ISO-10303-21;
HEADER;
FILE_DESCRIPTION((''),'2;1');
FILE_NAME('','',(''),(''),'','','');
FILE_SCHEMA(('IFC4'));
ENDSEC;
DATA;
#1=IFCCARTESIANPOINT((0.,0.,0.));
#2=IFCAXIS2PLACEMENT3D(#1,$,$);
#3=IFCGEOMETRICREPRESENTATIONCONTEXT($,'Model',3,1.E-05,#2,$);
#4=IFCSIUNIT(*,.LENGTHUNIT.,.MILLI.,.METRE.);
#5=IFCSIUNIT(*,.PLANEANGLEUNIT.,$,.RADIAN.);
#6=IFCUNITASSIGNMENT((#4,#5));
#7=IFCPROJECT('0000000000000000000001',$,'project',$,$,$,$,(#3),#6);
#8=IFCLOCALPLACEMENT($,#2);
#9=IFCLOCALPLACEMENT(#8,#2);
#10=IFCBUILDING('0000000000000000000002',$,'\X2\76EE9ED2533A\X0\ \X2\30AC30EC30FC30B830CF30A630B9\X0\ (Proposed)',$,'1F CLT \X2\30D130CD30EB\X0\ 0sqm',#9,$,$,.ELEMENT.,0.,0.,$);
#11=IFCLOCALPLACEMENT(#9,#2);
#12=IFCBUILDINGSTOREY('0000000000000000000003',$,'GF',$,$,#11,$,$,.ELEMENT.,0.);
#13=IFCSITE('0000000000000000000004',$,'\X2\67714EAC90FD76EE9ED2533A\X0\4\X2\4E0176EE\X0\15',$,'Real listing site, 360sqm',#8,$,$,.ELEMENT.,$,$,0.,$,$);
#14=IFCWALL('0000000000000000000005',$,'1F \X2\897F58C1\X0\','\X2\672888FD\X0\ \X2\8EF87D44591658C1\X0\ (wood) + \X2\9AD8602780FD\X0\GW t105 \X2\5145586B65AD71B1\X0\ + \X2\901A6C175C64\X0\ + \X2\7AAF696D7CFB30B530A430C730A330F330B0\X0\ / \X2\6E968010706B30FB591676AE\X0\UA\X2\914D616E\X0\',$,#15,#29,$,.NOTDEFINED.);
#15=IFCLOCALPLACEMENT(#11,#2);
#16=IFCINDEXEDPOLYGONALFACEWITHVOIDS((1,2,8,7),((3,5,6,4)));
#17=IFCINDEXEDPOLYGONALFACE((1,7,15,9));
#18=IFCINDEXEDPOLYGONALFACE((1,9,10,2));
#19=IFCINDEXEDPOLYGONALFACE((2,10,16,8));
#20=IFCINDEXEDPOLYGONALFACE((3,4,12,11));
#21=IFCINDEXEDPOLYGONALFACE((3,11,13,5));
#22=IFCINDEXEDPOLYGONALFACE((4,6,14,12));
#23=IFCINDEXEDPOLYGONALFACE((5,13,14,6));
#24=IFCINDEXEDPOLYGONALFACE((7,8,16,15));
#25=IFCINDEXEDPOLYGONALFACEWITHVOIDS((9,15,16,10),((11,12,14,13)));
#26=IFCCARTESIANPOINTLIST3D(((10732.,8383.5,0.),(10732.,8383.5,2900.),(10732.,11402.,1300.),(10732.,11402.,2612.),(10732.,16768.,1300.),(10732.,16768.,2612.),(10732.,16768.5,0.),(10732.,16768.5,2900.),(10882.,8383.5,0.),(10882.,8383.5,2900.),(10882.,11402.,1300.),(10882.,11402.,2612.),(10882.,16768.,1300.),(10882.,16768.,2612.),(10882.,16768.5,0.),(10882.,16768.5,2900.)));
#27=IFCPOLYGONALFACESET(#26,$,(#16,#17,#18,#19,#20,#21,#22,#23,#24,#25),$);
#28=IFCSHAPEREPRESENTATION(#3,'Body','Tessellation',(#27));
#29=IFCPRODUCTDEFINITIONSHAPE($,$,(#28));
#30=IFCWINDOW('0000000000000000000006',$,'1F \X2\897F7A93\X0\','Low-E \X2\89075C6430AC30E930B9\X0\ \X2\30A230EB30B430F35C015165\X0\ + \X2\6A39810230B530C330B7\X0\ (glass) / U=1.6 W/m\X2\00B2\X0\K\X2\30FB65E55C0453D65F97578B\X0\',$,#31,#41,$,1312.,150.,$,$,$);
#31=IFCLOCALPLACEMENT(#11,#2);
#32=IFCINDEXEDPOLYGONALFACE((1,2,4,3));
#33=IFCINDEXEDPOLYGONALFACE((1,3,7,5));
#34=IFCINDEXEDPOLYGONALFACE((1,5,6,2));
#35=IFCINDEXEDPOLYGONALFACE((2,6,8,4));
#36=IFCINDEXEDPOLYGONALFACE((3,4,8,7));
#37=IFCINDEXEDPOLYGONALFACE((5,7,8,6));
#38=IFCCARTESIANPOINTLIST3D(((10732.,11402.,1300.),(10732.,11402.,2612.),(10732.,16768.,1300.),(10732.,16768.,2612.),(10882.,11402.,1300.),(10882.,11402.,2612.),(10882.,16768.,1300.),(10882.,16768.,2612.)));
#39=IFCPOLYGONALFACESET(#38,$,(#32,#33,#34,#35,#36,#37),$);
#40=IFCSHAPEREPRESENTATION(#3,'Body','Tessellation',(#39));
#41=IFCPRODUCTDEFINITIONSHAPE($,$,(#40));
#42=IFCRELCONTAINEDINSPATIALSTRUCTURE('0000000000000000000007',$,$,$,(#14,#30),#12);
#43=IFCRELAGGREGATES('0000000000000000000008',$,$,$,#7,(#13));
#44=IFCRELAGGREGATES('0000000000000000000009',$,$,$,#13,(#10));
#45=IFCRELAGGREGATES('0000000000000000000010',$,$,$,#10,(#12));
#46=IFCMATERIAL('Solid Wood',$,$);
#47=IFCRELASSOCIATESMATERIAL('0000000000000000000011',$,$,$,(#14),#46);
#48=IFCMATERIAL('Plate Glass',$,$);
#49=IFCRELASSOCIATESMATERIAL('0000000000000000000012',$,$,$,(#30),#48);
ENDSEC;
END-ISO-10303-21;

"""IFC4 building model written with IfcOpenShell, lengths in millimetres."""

from ifc_helpers import new_model, si_unit, frame, frame_2d, origin, place, context, project, spatial, rectangle, extrude, material, element, fill, save


model = new_model("IFC4")

# Units and contexts
model_context = context("Model", 3, precision=1e-05, world=origin())
ifc_project = project(units=[si_unit("LENGTHUNIT", "METRE", prefix="MILLI"), si_unit("PLANEANGLEUNIT", "RADIAN")], contexts=[model_context])

# Site, building, storey
site_placement = place(None, origin())
site = spatial("IfcSite", under=ifc_project, at=site_placement, Name="東京都目黒区4丁目15", ObjectType="Real listing site, 360sqm", CompositionType="ELEMENT", RefElevation=0.0)
building_placement = place(site_placement, origin())
building = spatial("IfcBuilding", under=site, at=building_placement, Name="目黒区 ガレージハウス (Proposed)", ObjectType="1F CLT パネル 0sqm", CompositionType="ELEMENT", ElevationOfRefHeight=0.0, ElevationOfTerrain=0.0)
storey_placement = place(building_placement, origin())
storey = spatial("IfcBuildingStorey", under=building, at=storey_placement, Name="GF", CompositionType="ELEMENT", Elevation=0.0)

# Shared definitions
ifc_material_1 = material(Name="Solid Wood")

# Shared definitions
ifc_material_2 = material(Name="Plate Glass")

# Wall, opening, window
wall_1_placement = place(storey_placement, frame((5366.0, 4192.0, 0.0)))
wall_1 = element("IfcWall", 1, at=wall_1_placement, inside=storey, material=ifc_material_1, Name="1F 西壁", Description="木製 軸組外壁 (wood) + 高性能GW t105 充填断熱 + 通気層 + 窯業系サイディング / 準耐火・外皮UA配慮", PredefinedType="NOTDEFINED", context=model_context, shape_type="SweptSolid", body=[
    extrude(rectangle(XDim=150.0, YDim=8385.0, at=frame_2d((75.0, 4192.0))), frame((5366.0, 4192.0, 0.0)), (0.0, 0.0, 1.0), 2900.0),
])
opening_1_placement = place(storey_placement, frame((5366.0, 5701.0, 650.0)))
opening_1 = element("IfcOpeningElement", 2, at=opening_1_placement, cuts=wall_1, PredefinedType="NOTDEFINED", context=model_context, shape_type="SweptSolid", body=[
    extrude(rectangle(XDim=150.0, YDim=5366.0, at=frame_2d((75.0, 2683.0))), frame((5366.0, 5701.0, 650.0)), (0.0, 0.0, 1.0), 1312.0),
])
window_1_placement = place(storey_placement, frame((5366.0, 5701.0, 650.0)))
window_1 = element("IfcWindow", 3, at=window_1_placement, inside=storey, material=ifc_material_2, Name="1F 西窓", Description="Low-E 複層ガラス アルゴン封入 + 樹脂サッシ (glass) / U=1.6 W/m²K・日射取得型", OverallHeight=1312.0, OverallWidth=150.0, context=model_context, shape_type="SweptSolid", body=[
    extrude(rectangle(XDim=150.0, YDim=5366.0, at=frame_2d((75.0, 2683.0))), frame((5366.0, 5701.0, 650.0)), (0.0, 0.0, 1.0), 1312.0),
])
fill(opening_1, window_1)

save(model, "model.ifc")
